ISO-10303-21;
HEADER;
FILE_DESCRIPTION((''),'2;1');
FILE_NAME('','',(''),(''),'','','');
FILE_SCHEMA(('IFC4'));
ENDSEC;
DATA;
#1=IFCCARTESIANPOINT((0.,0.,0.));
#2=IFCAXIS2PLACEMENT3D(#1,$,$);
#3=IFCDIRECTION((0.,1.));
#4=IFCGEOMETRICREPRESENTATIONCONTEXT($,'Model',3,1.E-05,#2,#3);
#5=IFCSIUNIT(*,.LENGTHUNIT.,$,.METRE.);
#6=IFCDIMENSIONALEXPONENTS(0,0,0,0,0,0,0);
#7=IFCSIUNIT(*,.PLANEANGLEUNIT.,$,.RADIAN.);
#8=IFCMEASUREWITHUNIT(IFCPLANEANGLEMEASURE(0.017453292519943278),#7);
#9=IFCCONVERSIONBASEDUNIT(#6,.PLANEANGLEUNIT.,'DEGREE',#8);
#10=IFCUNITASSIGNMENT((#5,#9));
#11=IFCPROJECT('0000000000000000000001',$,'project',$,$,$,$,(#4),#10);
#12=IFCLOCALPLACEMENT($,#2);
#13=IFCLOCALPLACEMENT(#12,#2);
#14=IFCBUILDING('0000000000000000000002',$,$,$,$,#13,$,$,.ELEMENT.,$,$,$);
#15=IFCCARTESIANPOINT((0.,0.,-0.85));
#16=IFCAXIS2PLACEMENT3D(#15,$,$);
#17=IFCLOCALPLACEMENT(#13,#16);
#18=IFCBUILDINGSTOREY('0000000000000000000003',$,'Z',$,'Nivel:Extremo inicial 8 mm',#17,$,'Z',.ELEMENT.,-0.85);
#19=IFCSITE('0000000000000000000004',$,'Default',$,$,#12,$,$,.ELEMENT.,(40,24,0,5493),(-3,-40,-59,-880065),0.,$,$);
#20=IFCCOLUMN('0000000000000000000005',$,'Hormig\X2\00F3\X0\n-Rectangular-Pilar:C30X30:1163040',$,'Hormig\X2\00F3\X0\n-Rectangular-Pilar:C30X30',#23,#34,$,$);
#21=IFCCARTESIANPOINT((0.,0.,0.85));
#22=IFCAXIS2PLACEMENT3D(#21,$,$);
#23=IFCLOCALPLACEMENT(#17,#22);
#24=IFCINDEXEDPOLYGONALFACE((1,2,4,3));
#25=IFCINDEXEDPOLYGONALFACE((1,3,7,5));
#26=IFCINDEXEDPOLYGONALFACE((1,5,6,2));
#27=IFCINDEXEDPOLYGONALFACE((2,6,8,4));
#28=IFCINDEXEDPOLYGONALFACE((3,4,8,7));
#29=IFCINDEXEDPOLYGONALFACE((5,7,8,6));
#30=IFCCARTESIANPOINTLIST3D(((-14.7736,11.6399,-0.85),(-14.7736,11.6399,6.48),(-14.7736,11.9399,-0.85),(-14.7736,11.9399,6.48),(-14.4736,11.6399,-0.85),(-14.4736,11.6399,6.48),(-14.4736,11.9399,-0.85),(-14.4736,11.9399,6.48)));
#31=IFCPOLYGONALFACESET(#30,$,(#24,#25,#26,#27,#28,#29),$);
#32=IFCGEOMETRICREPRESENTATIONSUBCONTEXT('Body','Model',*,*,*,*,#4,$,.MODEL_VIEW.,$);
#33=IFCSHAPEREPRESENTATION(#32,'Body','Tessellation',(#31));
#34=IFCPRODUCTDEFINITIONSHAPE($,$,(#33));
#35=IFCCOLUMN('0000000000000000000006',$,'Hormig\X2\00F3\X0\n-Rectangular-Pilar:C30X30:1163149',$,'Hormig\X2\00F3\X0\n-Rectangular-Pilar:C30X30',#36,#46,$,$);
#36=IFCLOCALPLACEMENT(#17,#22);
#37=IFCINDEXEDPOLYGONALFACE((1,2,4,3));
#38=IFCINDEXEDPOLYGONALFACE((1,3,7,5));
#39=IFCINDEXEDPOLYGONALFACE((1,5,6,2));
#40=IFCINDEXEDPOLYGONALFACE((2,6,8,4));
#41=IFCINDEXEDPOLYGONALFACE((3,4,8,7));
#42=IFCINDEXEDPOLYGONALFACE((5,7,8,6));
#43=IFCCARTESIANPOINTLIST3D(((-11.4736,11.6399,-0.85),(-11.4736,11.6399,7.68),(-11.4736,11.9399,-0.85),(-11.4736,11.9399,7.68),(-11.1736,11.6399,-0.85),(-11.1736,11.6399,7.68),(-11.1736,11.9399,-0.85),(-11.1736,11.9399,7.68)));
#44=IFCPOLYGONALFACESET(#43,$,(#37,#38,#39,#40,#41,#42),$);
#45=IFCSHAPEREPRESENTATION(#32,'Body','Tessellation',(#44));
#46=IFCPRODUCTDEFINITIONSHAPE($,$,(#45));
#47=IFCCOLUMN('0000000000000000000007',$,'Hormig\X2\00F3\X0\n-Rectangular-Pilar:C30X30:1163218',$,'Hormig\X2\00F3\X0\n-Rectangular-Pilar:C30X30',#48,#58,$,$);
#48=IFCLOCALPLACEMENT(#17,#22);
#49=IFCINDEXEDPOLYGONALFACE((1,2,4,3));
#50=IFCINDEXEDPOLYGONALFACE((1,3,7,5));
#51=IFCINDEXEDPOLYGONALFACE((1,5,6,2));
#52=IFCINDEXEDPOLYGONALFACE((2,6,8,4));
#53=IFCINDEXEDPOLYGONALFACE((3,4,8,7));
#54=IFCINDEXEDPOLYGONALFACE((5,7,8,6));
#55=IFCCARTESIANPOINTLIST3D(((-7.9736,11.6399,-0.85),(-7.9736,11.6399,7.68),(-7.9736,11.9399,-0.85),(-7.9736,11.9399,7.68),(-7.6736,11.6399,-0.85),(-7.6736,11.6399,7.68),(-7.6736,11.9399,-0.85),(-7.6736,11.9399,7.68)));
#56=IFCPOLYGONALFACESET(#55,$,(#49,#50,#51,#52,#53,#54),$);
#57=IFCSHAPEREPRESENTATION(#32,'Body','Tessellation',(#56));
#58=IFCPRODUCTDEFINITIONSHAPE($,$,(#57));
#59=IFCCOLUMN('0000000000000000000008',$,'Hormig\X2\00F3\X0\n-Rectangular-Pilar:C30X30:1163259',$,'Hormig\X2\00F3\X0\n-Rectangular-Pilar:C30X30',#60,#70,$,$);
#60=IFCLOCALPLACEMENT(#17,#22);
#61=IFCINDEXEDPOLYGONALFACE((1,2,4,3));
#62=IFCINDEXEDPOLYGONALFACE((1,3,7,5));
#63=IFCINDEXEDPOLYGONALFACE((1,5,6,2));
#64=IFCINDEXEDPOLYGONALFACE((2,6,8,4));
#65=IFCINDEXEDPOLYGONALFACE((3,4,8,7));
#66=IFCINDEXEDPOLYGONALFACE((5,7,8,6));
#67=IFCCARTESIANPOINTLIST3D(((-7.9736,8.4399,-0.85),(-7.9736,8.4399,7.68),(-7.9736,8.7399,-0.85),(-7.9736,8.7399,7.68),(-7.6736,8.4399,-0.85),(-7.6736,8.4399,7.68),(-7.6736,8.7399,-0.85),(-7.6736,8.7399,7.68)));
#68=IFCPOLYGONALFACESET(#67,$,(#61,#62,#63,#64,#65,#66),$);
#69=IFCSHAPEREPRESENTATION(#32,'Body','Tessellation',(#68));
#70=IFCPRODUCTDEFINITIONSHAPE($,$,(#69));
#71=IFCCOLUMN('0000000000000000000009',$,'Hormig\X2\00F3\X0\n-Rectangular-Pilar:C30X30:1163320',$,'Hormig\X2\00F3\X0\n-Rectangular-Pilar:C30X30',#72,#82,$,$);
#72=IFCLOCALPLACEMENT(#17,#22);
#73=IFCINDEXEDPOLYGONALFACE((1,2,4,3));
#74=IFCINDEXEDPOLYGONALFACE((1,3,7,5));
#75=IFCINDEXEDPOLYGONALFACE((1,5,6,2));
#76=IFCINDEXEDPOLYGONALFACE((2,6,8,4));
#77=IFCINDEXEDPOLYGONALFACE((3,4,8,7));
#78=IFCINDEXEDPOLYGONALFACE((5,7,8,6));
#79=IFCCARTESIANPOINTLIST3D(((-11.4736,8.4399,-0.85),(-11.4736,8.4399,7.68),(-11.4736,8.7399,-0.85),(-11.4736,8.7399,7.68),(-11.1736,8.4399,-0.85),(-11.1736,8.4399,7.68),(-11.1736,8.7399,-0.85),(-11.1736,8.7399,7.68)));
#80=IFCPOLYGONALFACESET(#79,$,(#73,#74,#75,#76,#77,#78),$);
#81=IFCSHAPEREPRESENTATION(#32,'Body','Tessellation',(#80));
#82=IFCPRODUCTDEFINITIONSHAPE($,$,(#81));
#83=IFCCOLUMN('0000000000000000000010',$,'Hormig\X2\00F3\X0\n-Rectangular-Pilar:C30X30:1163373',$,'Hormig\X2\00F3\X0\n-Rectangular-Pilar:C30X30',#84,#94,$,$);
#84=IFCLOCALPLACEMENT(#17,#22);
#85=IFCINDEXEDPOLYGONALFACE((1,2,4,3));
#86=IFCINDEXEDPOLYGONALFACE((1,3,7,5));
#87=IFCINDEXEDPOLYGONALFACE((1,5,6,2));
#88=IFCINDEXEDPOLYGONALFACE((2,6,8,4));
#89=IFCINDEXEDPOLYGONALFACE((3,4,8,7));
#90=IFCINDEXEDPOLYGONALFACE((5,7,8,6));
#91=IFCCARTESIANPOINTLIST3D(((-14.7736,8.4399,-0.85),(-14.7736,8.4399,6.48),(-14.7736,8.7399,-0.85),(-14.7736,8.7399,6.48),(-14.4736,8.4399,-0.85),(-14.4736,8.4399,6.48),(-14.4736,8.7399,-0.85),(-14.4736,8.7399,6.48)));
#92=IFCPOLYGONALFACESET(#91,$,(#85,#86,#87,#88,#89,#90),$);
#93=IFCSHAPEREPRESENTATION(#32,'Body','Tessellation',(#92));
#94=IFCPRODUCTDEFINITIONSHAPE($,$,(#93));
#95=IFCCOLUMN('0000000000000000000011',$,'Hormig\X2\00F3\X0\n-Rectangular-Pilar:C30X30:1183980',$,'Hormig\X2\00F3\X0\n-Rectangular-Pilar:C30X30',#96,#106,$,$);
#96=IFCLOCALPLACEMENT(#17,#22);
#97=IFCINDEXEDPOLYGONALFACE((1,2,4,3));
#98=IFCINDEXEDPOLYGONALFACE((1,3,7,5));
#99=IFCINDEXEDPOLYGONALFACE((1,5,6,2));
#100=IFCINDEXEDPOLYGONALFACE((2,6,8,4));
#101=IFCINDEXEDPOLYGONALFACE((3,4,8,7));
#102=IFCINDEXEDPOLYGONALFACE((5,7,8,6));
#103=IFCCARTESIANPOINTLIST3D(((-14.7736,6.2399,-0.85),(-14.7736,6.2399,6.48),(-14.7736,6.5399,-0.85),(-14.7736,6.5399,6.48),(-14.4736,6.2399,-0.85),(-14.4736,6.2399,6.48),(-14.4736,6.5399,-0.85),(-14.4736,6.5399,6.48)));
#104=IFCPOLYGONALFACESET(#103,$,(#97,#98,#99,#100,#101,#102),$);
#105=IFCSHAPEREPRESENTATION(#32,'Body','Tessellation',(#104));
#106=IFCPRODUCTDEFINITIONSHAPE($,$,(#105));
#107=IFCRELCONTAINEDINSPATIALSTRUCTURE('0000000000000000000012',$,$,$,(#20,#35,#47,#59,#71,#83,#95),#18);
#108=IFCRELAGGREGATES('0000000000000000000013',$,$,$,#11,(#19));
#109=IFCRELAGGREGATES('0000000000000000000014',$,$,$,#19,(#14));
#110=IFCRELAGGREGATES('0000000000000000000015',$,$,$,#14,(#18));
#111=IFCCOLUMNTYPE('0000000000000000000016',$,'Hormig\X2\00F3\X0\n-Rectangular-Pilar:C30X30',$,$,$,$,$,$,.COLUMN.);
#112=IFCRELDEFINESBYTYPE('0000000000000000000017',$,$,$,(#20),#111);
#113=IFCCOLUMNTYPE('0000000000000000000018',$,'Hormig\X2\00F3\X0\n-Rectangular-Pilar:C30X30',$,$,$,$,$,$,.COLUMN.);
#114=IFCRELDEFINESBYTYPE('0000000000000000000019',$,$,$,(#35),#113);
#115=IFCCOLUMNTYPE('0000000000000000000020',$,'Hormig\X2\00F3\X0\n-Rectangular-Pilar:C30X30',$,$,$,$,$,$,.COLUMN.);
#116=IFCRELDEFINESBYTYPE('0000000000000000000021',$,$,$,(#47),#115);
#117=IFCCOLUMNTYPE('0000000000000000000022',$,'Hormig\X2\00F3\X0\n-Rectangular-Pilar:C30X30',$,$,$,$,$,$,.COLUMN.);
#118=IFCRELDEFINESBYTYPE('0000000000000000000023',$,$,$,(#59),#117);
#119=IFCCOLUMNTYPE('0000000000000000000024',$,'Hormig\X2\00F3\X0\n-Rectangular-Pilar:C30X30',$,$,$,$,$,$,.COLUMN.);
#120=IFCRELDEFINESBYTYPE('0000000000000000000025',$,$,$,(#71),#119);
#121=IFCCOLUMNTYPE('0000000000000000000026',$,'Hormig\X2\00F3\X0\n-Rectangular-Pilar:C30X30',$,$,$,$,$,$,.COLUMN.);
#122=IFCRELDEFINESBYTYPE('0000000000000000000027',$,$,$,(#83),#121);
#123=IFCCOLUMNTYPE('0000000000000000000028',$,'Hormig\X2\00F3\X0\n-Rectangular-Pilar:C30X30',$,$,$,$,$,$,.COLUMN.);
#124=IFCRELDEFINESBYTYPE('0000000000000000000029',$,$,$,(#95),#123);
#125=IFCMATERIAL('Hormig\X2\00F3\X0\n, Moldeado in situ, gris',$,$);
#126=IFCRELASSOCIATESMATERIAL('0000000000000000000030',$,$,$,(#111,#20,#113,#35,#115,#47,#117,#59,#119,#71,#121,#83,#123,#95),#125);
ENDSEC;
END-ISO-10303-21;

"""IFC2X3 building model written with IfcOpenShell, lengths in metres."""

from ifc_helpers import new_model, entity, si_unit, converted_unit, direction, frame, frame_2d, origin, place, context, subcontext, project, spatial, rectangle, extrude, source, transform, mapped, material, type_object, type_shapes, element, save


model = new_model("IFC2X3")

# Units and contexts
model_context = context("Model", 3, precision=1e-05, world=origin(), true_north=direction((0.0, 1.0)))
body_context = subcontext(model_context, "Body", "Model", "MODEL_VIEW")
ifc_project = project(units=[si_unit("LENGTHUNIT", "METRE"), converted_unit("PLANEANGLEUNIT", "DEGREE", entity("IfcPlaneAngleMeasure", 0.017453292519943278), si_unit("PLANEANGLEUNIT", "RADIAN"), dimensions=[0, 0, 0, 0, 0, 0, 0])], contexts=[model_context])

# Site, building, storey
site_placement = place(None, origin())
site = spatial("IfcSite", under=ifc_project, at=site_placement, Name="Default", CompositionType="ELEMENT", RefLatitude=(40, 24, 0, 5493), RefLongitude=(-3, -40, -59, -880065), RefElevation=0.0)
building_placement = place(site_placement, origin())
building = spatial("IfcBuilding", under=site, at=building_placement, CompositionType="ELEMENT")
storey_placement = place(building_placement, frame((0.0, 0.0, -0.85)))
storey = spatial("IfcBuildingStorey", under=building, at=storey_placement, Name="Z", ObjectType="Nivel:Extremo inicial 8 mm", LongName="Z", CompositionType="ELEMENT", Elevation=-0.85)

# Columns
ifc_material_1 = material(Name="Hormigón, Moldeado in situ, gris")
column_type_1 = type_object("IfcColumnType", Name="Hormigón-Rectangular-Pilar:C30X30", PredefinedType="COLUMN", material=ifc_material_1)
shared_shape_1 = source(origin(), body_context, "Body", "SweptSolid", [
    extrude(rectangle(XDim=0.3, YDim=0.3, at=frame_2d((0.0, 0.0), x_axis=(1.0, 0.0))), frame((-14.6236, 11.7899, -0.85), z_axis=(0.0, 0.0, 1.0), x_axis=(-1.0, 0.0, 0.0)), (0.0, 0.0, 1.0), 7.33),
])
type_shapes(column_type_1, [shared_shape_1])
column_1_placement = place(storey_placement, frame((0.0, 0.0, 0.85)))
element("IfcColumn", 1, at=column_1_placement, inside=storey, type_object=column_type_1, material=ifc_material_1, Name="Hormigón-Rectangular-Pilar:C30X30:1163040", ObjectType="Hormigón-Rectangular-Pilar:C30X30", context=body_context, shape_type="MappedRepresentation", body=[
    mapped(shared_shape_1, transform((0.0, 0.0, 0.0), scale=1.0)),
])
column_type_2 = type_object("IfcColumnType", Name="Hormigón-Rectangular-Pilar:C30X30", PredefinedType="COLUMN", material=ifc_material_1)
shared_shape_2 = source(origin(), body_context, "Body", "SweptSolid", [
    extrude(rectangle(XDim=0.3, YDim=0.3, at=frame_2d((0.0, 0.0), x_axis=(1.0, 0.0))), frame((-11.3236, 11.7899, -0.85), z_axis=(0.0, 0.0, 1.0), x_axis=(-1.0, 0.0, 0.0)), (0.0, 0.0, 1.0), 8.53),
])
type_shapes(column_type_2, [shared_shape_2])
column_2_placement = place(storey_placement, frame((0.0, 0.0, 0.85)))
element("IfcColumn", 2, at=column_2_placement, inside=storey, type_object=column_type_2, material=ifc_material_1, Name="Hormigón-Rectangular-Pilar:C30X30:1163149", ObjectType="Hormigón-Rectangular-Pilar:C30X30", context=body_context, shape_type="MappedRepresentation", body=[
    mapped(shared_shape_2, transform((0.0, 0.0, 0.0), scale=1.0)),
])
column_type_3 = type_object("IfcColumnType", Name="Hormigón-Rectangular-Pilar:C30X30", PredefinedType="COLUMN", material=ifc_material_1)
shared_shape_3 = source(origin(), body_context, "Body", "SweptSolid", [
    extrude(rectangle(XDim=0.3, YDim=0.3, at=frame_2d((0.0, 0.0), x_axis=(1.0, 0.0))), frame((-7.8236, 11.7899, -0.85), z_axis=(0.0, 0.0, 1.0), x_axis=(-1.0, 0.0, 0.0)), (0.0, 0.0, 1.0), 8.53),
])
type_shapes(column_type_3, [shared_shape_3])
column_3_placement = place(storey_placement, frame((0.0, 0.0, 0.85)))
element("IfcColumn", 3, at=column_3_placement, inside=storey, type_object=column_type_3, material=ifc_material_1, Name="Hormigón-Rectangular-Pilar:C30X30:1163218", ObjectType="Hormigón-Rectangular-Pilar:C30X30", context=body_context, shape_type="MappedRepresentation", body=[
    mapped(shared_shape_3, transform((0.0, 0.0, 0.0), scale=1.0)),
])
column_type_4 = type_object("IfcColumnType", Name="Hormigón-Rectangular-Pilar:C30X30", PredefinedType="COLUMN", material=ifc_material_1)
shared_shape_4 = source(origin(), body_context, "Body", "SweptSolid", [
    extrude(rectangle(XDim=0.3, YDim=0.3, at=frame_2d((0.0, 0.0), x_axis=(1.0, 0.0))), frame((-7.8236, 8.5899, -0.85), z_axis=(0.0, 0.0, 1.0), x_axis=(-1.0, 0.0, 0.0)), (0.0, 0.0, 1.0), 8.53),
])
type_shapes(column_type_4, [shared_shape_4])
column_4_placement = place(storey_placement, frame((0.0, 0.0, 0.85)))
element("IfcColumn", 4, at=column_4_placement, inside=storey, type_object=column_type_4, material=ifc_material_1, Name="Hormigón-Rectangular-Pilar:C30X30:1163259", ObjectType="Hormigón-Rectangular-Pilar:C30X30", context=body_context, shape_type="MappedRepresentation", body=[
    mapped(shared_shape_4, transform((0.0, 0.0, 0.0), scale=1.0)),
])
column_type_5 = type_object("IfcColumnType", Name="Hormigón-Rectangular-Pilar:C30X30", PredefinedType="COLUMN", material=ifc_material_1)
shared_shape_5 = source(origin(), body_context, "Body", "SweptSolid", [
    extrude(rectangle(XDim=0.3, YDim=0.3, at=frame_2d((0.0, 0.0), x_axis=(1.0, 0.0))), frame((-11.3236, 8.5899, -0.85), z_axis=(0.0, 0.0, 1.0), x_axis=(-1.0, 0.0, 0.0)), (0.0, 0.0, 1.0), 8.53),
])
type_shapes(column_type_5, [shared_shape_5])
column_5_placement = place(storey_placement, frame((0.0, 0.0, 0.85)))
element("IfcColumn", 5, at=column_5_placement, inside=storey, type_object=column_type_5, material=ifc_material_1, Name="Hormigón-Rectangular-Pilar:C30X30:1163320", ObjectType="Hormigón-Rectangular-Pilar:C30X30", context=body_context, shape_type="MappedRepresentation", body=[
    mapped(shared_shape_5, transform((0.0, 0.0, 0.0), scale=1.0)),
])
column_type_6 = type_object("IfcColumnType", Name="Hormigón-Rectangular-Pilar:C30X30", PredefinedType="COLUMN", material=ifc_material_1)
shared_shape_6 = source(origin(), body_context, "Body", "SweptSolid", [
    extrude(rectangle(XDim=0.3, YDim=0.3, at=frame_2d((0.0, 0.0), x_axis=(1.0, 0.0))), frame((-14.6236, 8.5899, -0.85), z_axis=(0.0, 0.0, 1.0), x_axis=(-1.0, 0.0, 0.0)), (0.0, 0.0, 1.0), 7.33),
])
type_shapes(column_type_6, [shared_shape_6])
column_6_placement = place(storey_placement, frame((0.0, 0.0, 0.85)))
element("IfcColumn", 6, at=column_6_placement, inside=storey, type_object=column_type_6, material=ifc_material_1, Name="Hormigón-Rectangular-Pilar:C30X30:1163373", ObjectType="Hormigón-Rectangular-Pilar:C30X30", context=body_context, shape_type="MappedRepresentation", body=[
    mapped(shared_shape_6, transform((0.0, 0.0, 0.0), scale=1.0)),
])
column_type_7 = type_object("IfcColumnType", Name="Hormigón-Rectangular-Pilar:C30X30", PredefinedType="COLUMN", material=ifc_material_1)
shared_shape_7 = source(origin(), body_context, "Body", "SweptSolid", [
    extrude(rectangle(XDim=0.3, YDim=0.3, at=frame_2d((0.0, 0.0), x_axis=(1.0, 0.0))), frame((-14.6236, 6.3899, -0.85), z_axis=(0.0, 0.0, 1.0), x_axis=(-1.0, 0.0, 0.0)), (0.0, 0.0, 1.0), 7.33),
])
type_shapes(column_type_7, [shared_shape_7])
column_7_placement = place(storey_placement, frame((0.0, 0.0, 0.85)))
element("IfcColumn", 7, at=column_7_placement, inside=storey, type_object=column_type_7, material=ifc_material_1, Name="Hormigón-Rectangular-Pilar:C30X30:1183980", ObjectType="Hormigón-Rectangular-Pilar:C30X30", context=body_context, shape_type="MappedRepresentation", body=[
    mapped(shared_shape_7, transform((0.0, 0.0, 0.0), scale=1.0)),
])

save(model, "model.ifc")
